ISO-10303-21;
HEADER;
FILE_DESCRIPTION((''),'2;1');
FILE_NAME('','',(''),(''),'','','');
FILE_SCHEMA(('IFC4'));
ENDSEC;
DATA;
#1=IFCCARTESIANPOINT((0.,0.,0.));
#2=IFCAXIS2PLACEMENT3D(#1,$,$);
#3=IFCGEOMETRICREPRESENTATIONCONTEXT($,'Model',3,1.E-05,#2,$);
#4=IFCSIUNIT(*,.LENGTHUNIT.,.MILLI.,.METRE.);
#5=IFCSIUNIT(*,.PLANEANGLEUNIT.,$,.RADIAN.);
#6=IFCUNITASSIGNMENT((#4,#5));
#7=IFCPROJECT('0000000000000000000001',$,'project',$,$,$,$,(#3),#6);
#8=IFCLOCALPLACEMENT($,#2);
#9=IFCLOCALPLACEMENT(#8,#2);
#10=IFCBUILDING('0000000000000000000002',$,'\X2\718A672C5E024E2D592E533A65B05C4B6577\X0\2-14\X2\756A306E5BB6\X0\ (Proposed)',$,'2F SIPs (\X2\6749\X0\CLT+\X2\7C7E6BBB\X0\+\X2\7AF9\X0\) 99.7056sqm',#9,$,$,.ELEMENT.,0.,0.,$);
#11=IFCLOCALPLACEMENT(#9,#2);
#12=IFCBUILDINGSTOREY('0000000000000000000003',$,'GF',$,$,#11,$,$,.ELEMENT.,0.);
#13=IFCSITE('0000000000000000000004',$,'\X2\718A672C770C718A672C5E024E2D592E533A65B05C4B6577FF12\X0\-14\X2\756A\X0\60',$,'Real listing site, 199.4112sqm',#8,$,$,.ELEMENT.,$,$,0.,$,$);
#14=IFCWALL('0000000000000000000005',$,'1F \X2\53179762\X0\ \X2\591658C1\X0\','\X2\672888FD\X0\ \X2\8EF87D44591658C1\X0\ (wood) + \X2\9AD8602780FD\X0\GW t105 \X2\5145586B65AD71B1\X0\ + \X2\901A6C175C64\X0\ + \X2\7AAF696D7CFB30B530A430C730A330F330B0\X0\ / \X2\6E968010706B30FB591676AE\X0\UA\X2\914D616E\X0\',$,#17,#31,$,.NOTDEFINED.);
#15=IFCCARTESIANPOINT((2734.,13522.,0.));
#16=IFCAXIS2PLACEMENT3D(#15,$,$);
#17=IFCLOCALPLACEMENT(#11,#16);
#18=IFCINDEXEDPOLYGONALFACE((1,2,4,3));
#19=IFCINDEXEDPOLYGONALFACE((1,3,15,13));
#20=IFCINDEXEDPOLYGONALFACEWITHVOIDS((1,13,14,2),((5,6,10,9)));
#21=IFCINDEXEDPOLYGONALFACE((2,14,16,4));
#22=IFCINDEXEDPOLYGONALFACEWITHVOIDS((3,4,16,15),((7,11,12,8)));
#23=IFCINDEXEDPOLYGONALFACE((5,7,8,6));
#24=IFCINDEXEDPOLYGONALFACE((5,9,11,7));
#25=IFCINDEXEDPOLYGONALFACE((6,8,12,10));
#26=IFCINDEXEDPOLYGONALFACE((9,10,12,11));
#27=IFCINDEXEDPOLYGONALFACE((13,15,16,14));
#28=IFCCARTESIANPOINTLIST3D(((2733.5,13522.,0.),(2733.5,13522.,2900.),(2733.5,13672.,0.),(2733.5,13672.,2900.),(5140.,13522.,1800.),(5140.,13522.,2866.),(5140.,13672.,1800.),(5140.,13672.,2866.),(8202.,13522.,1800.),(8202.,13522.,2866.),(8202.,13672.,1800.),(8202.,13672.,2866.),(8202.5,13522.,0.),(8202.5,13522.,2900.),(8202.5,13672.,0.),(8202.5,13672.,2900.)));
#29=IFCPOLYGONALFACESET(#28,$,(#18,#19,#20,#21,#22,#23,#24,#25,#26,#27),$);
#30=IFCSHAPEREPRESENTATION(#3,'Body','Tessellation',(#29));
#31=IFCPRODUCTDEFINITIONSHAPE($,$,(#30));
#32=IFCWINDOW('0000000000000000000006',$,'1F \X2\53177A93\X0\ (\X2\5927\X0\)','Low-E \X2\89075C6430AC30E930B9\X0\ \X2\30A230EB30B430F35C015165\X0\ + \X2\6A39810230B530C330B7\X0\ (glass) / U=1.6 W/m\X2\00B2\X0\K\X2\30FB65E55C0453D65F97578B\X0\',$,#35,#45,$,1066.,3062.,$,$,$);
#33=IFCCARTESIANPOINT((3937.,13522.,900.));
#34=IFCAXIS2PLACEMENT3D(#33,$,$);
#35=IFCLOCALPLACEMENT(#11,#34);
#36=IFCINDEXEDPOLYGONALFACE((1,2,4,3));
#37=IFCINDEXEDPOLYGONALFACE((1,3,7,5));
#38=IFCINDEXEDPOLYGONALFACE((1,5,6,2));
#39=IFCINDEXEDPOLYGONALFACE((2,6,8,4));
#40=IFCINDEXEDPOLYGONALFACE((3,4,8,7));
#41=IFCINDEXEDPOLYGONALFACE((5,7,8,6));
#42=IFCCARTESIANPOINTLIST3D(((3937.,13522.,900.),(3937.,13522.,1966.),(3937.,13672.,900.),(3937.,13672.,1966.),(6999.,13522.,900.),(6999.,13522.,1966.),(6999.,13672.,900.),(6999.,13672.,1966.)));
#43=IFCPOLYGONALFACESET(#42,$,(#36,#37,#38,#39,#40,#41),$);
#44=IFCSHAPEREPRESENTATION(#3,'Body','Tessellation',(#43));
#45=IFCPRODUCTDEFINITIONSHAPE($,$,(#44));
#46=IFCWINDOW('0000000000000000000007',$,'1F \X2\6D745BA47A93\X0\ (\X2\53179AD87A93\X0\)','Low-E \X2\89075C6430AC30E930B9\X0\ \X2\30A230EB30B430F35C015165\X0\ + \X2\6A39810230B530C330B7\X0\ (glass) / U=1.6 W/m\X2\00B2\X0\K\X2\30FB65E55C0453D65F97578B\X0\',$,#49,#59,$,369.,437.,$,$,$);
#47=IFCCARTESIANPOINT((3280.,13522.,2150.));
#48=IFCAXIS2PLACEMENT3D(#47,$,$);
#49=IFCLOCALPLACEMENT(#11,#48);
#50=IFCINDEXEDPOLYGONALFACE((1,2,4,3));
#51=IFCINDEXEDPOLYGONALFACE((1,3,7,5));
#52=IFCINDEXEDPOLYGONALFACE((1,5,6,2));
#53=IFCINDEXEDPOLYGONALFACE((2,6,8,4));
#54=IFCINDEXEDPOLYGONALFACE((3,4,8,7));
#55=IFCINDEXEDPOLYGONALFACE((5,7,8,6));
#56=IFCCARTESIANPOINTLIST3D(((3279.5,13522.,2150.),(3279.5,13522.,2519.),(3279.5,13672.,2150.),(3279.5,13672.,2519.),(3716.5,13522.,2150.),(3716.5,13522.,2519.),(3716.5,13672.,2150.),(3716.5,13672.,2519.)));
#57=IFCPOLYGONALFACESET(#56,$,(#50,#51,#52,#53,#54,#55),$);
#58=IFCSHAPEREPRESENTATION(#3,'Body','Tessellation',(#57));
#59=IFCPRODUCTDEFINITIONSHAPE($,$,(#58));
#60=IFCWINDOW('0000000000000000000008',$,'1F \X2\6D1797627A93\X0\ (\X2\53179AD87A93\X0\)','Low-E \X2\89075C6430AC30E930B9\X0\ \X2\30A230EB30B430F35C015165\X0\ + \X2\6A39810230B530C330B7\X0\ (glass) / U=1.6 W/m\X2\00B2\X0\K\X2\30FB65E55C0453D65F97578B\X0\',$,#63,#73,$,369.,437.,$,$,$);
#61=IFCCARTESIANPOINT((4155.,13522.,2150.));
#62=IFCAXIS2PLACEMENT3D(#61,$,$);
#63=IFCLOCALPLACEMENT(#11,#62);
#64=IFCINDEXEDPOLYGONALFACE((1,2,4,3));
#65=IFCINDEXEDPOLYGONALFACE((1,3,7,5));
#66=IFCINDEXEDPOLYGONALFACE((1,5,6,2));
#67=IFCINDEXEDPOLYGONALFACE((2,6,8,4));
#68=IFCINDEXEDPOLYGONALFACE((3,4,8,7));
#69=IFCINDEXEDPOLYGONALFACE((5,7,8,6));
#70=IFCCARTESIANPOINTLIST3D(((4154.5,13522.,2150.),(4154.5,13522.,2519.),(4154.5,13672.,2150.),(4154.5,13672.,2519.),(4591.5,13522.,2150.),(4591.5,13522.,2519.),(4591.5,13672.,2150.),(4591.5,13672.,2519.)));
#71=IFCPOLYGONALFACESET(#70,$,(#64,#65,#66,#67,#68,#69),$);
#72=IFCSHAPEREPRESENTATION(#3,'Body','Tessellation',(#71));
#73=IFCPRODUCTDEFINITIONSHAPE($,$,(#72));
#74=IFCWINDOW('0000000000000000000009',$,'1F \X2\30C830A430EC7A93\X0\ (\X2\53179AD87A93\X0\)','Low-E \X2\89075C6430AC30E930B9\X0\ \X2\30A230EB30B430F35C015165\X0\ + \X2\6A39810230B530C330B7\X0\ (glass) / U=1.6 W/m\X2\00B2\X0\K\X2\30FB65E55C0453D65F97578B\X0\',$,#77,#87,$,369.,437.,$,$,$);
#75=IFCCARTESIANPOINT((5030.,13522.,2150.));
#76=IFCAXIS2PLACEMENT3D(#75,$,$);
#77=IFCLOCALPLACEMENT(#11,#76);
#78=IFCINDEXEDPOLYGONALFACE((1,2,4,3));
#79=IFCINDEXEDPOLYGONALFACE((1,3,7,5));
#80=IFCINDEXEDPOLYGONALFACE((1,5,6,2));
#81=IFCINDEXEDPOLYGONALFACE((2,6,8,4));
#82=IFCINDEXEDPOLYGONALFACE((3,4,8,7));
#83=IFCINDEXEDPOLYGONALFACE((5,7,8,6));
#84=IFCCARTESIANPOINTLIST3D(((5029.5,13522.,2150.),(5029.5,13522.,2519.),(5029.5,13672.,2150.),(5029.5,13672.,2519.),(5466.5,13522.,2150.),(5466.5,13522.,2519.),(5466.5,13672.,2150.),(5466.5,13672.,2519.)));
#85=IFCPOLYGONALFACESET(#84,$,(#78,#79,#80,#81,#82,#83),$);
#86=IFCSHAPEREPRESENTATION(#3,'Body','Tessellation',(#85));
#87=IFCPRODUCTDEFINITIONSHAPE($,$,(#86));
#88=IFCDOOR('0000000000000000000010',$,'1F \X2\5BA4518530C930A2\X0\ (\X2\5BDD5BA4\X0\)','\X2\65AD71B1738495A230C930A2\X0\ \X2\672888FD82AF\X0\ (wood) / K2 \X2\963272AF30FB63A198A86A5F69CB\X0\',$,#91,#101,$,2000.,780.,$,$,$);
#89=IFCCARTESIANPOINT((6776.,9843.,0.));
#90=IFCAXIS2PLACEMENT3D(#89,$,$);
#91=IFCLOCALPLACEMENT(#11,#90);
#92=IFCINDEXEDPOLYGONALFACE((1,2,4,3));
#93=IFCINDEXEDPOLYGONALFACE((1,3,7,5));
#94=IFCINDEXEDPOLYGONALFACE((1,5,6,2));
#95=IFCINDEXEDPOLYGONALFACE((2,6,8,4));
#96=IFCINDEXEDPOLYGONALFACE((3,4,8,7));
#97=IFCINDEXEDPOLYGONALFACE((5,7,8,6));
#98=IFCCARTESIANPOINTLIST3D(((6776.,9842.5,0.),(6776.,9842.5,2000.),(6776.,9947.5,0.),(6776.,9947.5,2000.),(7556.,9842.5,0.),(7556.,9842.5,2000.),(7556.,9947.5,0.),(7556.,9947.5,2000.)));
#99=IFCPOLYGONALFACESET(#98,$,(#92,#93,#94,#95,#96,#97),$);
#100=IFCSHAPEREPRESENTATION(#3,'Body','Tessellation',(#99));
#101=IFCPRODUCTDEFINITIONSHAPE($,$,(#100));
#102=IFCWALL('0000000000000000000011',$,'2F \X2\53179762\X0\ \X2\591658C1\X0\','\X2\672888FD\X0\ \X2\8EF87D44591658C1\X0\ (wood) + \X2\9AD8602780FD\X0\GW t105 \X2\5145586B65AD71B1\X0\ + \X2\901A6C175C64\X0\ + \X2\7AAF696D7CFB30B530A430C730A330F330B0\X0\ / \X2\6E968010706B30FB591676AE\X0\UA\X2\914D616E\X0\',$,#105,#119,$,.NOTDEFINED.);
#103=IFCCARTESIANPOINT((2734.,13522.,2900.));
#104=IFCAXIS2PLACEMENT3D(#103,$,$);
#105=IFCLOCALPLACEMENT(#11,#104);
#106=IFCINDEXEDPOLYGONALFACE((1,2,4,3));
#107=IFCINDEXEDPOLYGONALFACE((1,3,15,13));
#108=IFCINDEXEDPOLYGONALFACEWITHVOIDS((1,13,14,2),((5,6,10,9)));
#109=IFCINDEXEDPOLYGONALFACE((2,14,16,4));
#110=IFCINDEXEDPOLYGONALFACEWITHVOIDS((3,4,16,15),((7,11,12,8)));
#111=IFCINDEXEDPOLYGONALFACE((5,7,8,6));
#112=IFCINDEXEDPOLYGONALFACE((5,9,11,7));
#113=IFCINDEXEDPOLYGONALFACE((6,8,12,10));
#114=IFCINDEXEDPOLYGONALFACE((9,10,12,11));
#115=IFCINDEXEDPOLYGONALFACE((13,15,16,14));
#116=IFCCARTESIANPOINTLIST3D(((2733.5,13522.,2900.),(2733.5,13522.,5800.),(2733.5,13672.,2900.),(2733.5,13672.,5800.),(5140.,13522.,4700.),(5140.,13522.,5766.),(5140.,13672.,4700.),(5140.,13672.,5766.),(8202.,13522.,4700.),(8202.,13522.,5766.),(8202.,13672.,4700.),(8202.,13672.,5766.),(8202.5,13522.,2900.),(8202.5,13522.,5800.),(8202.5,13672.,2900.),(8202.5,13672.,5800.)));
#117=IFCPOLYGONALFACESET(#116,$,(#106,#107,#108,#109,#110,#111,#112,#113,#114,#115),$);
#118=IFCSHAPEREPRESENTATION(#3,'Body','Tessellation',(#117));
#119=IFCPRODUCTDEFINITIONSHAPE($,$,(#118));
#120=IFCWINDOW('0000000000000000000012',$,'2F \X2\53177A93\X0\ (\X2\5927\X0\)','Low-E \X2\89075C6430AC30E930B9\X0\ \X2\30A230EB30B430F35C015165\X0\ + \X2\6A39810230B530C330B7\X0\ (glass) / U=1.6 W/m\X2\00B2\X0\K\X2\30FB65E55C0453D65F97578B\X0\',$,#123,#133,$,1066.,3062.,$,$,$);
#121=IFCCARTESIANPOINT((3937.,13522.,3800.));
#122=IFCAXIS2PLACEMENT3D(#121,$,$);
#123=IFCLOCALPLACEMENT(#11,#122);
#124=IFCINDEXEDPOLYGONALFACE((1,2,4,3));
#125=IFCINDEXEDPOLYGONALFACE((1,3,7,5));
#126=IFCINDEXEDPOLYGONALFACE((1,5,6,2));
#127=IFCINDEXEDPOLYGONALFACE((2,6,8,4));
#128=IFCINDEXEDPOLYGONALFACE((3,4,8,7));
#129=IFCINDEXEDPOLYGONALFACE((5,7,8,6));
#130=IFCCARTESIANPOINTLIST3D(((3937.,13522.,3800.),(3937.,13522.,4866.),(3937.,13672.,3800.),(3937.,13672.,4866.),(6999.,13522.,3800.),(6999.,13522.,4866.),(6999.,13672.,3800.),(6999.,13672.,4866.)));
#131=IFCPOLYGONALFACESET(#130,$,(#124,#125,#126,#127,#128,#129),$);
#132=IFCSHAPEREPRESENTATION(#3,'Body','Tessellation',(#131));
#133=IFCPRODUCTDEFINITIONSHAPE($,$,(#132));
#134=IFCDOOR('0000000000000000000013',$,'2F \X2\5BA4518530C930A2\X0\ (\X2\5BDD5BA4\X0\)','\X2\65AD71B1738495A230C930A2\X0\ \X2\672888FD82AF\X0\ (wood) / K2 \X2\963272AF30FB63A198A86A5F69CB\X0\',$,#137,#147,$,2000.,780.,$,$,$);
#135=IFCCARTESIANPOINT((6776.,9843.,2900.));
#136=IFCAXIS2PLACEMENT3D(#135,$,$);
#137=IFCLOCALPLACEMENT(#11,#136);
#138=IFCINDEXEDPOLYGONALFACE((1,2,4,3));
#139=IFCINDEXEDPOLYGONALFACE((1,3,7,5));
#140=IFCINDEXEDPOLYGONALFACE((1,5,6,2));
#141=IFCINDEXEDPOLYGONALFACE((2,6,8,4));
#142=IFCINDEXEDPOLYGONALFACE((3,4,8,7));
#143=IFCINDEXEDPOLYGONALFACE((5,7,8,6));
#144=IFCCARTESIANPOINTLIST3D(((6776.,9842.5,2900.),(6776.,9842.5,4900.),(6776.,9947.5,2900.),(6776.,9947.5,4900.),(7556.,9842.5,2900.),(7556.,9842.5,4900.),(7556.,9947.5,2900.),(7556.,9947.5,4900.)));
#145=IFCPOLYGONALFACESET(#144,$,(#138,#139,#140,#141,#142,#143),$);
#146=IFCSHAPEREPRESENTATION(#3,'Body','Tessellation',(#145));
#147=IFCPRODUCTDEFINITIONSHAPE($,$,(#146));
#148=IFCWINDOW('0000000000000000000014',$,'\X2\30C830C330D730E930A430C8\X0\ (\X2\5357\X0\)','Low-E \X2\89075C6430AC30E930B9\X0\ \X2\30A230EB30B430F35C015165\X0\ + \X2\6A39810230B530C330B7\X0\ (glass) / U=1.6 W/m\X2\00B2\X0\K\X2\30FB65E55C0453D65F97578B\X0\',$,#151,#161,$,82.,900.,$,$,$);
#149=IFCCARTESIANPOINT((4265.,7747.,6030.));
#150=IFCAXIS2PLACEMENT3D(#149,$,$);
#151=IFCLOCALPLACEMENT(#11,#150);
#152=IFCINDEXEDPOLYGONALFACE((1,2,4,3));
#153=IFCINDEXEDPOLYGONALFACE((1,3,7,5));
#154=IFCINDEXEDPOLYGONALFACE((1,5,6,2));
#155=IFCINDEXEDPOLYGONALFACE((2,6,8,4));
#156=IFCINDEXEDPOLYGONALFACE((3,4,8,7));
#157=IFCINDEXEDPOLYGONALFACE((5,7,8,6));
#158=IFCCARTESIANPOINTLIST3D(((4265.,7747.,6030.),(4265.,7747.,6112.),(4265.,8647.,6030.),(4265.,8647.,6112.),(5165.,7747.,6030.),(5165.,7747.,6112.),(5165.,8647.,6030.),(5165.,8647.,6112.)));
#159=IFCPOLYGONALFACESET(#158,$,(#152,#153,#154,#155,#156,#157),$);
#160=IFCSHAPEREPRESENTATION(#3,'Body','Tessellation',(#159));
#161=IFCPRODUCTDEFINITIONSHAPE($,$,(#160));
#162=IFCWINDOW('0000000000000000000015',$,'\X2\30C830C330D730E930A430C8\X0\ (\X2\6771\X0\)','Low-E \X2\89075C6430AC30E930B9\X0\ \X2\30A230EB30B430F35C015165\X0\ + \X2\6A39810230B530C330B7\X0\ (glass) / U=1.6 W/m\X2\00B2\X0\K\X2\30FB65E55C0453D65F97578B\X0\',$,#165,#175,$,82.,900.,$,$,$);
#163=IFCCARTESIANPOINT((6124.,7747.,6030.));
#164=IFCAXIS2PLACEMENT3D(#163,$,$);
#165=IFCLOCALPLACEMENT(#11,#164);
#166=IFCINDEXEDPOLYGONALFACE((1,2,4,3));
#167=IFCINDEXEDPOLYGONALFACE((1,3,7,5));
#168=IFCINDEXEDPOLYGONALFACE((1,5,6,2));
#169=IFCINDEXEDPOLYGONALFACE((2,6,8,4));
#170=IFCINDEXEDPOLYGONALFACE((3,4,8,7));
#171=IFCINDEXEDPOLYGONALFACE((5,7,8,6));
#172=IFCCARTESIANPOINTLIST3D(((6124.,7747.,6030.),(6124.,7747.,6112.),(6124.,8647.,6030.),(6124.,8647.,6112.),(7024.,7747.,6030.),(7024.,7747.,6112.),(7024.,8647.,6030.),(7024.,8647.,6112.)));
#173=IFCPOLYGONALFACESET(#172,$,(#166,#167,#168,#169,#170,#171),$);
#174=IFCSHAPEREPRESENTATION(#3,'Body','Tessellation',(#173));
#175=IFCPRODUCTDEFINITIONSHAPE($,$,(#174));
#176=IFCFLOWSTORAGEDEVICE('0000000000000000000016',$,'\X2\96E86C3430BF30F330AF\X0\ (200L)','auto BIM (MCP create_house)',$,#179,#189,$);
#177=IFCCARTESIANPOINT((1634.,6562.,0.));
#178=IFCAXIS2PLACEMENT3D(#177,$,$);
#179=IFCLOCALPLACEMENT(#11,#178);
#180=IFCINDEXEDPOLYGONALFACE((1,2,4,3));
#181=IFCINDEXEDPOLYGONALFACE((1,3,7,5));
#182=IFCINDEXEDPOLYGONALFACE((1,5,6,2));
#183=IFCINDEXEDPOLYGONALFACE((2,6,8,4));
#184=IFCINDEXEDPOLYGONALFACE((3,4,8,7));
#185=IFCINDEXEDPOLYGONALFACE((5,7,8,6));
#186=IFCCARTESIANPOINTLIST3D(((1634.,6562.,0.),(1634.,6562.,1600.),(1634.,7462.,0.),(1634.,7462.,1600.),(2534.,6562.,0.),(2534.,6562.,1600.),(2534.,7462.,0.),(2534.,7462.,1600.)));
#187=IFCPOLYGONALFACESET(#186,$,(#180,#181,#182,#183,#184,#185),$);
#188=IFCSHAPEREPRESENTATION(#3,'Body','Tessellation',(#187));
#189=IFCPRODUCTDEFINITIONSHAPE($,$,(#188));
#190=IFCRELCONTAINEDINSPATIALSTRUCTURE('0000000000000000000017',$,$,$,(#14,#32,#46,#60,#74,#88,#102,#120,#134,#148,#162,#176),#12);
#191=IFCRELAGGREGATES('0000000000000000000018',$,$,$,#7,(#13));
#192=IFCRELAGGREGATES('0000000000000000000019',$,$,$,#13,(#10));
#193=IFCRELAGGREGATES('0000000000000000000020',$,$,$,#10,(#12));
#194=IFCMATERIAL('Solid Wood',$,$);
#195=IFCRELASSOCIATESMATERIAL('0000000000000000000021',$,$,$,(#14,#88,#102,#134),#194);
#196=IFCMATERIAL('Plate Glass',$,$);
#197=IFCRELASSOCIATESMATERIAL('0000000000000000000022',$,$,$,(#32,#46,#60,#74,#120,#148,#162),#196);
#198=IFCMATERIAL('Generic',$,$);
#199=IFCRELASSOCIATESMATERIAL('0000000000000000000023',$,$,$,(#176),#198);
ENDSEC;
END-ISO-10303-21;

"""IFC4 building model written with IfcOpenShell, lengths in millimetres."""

from ifc_helpers import new_model, si_unit, frame, frame_2d, origin, place, context, project, spatial, rectangle, extrude, material, element, fill, save


model = new_model("IFC4")

# Units and contexts
model_context = context("Model", 3, precision=1e-05, world=origin())
ifc_project = project(units=[si_unit("LENGTHUNIT", "METRE", prefix="MILLI"), si_unit("PLANEANGLEUNIT", "RADIAN")], contexts=[model_context])

# Site, building, storey
site_placement = place(None, origin())
site = spatial("IfcSite", under=ifc_project, at=site_placement, Name="熊本県熊本市中央区新屋敷２-14番60", ObjectType="Real listing site, 199.4112sqm", CompositionType="ELEMENT", RefElevation=0.0)
building_placement = place(site_placement, origin())
building = spatial("IfcBuilding", under=site, at=building_placement, Name="熊本市中央区新屋敷2-14番の家 (Proposed)", ObjectType="2F SIPs (杉CLT+籾殻+竹) 99.7056sqm", CompositionType="ELEMENT", ElevationOfRefHeight=0.0, ElevationOfTerrain=0.0)
storey_placement = place(building_placement, origin())
storey = spatial("IfcBuildingStorey", under=building, at=storey_placement, Name="GF", CompositionType="ELEMENT", Elevation=0.0)

# Wall, openings, windows
ifc_material_1 = material(Name="Solid Wood")
wall_1_placement = place(storey_placement, frame((2734.0, 13522.0, 0.0)))
wall_1 = element("IfcWall", 1, at=wall_1_placement, inside=storey, material=ifc_material_1, Name="1F 北面 外壁", Description="木製 軸組外壁 (wood) + 高性能GW t105 充填断熱 + 通気層 + 窯業系サイディング / 準耐火・外皮UA配慮", PredefinedType="NOTDEFINED", context=model_context, shape_type="SweptSolid", body=[
    extrude(rectangle(XDim=5469.0, YDim=150.0, at=frame_2d((2734.0, 75.0))), frame((2734.0, 13522.0, 0.0)), (0.0, 0.0, 1.0), 2900.0),
])
opening_1_placement = place(storey_placement, frame((3937.0, 13522.0, 900.0)))
opening_1 = element("IfcOpeningElement", 2, at=opening_1_placement, cuts=wall_1, PredefinedType="NOTDEFINED", context=model_context, shape_type="SweptSolid", body=[
    extrude(rectangle(XDim=3062.0, YDim=150.0, at=frame_2d((1531.0, 75.0))), frame((3937.0, 13522.0, 900.0)), (0.0, 0.0, 1.0), 1066.0),
])
opening_2_placement = place(storey_placement, frame((3280.0, 13522.0, 2150.0)))
opening_2 = element("IfcOpeningElement", 3, at=opening_2_placement, cuts=wall_1, PredefinedType="NOTDEFINED", context=model_context, shape_type="SweptSolid", body=[
    extrude(rectangle(XDim=437.0, YDim=150.0, at=frame_2d((218.0, 75.0))), frame((3280.0, 13522.0, 2150.0)), (0.0, 0.0, 1.0), 369.0),
])
opening_3_placement = place(storey_placement, frame((4155.0, 13522.0, 2150.0)))
opening_3 = element("IfcOpeningElement", 4, at=opening_3_placement, cuts=wall_1, PredefinedType="NOTDEFINED", context=model_context, shape_type="SweptSolid", body=[
    extrude(rectangle(XDim=437.0, YDim=150.0, at=frame_2d((218.0, 75.0))), frame((4155.0, 13522.0, 2150.0)), (0.0, 0.0, 1.0), 369.0),
])
opening_4_placement = place(storey_placement, frame((5030.0, 13522.0, 2150.0)))
opening_4 = element("IfcOpeningElement", 5, at=opening_4_placement, cuts=wall_1, PredefinedType="NOTDEFINED", context=model_context, shape_type="SweptSolid", body=[
    extrude(rectangle(XDim=437.0, YDim=150.0, at=frame_2d((218.0, 75.0))), frame((5030.0, 13522.0, 2150.0)), (0.0, 0.0, 1.0), 369.0),
])
ifc_material_2 = material(Name="Plate Glass")
window_1_placement = place(storey_placement, frame((3937.0, 13522.0, 900.0)))
window_1 = element("IfcWindow", 6, at=window_1_placement, inside=storey, material=ifc_material_2, Name="1F 北窓 (大)", Description="Low-E 複層ガラス アルゴン封入 + 樹脂サッシ (glass) / U=1.6 W/m²K・日射取得型", OverallHeight=1066.0, OverallWidth=3062.0, context=model_context, shape_type="SweptSolid", body=[
    extrude(rectangle(XDim=3062.0, YDim=150.0, at=frame_2d((1531.0, 75.0))), frame((3937.0, 13522.0, 900.0)), (0.0, 0.0, 1.0), 1066.0),
])
fill(opening_1, window_1)
window_2_placement = place(storey_placement, frame((3280.0, 13522.0, 2150.0)))
window_2 = element("IfcWindow", 7, at=window_2_placement, inside=storey, material=ifc_material_2, Name="1F 浴室窓 (北高窓)", Description="Low-E 複層ガラス アルゴン封入 + 樹脂サッシ (glass) / U=1.6 W/m²K・日射取得型", OverallHeight=369.0, OverallWidth=437.0, context=model_context, shape_type="SweptSolid", body=[
    extrude(rectangle(XDim=437.0, YDim=150.0, at=frame_2d((218.0, 75.0))), frame((3280.0, 13522.0, 2150.0)), (0.0, 0.0, 1.0), 369.0),
])
fill(opening_2, window_2)
window_3_placement = place(storey_placement, frame((4155.0, 13522.0, 2150.0)))
window_3 = element("IfcWindow", 8, at=window_3_placement, inside=storey, material=ifc_material_2, Name="1F 洗面窓 (北高窓)", Description="Low-E 複層ガラス アルゴン封入 + 樹脂サッシ (glass) / U=1.6 W/m²K・日射取得型", OverallHeight=369.0, OverallWidth=437.0, context=model_context, shape_type="SweptSolid", body=[
    extrude(rectangle(XDim=437.0, YDim=150.0, at=frame_2d((218.0, 75.0))), frame((4155.0, 13522.0, 2150.0)), (0.0, 0.0, 1.0), 369.0),
])
fill(opening_3, window_3)
window_4_placement = place(storey_placement, frame((5030.0, 13522.0, 2150.0)))
window_4 = element("IfcWindow", 9, at=window_4_placement, inside=storey, material=ifc_material_2, Name="1F トイレ窓 (北高窓)", Description="Low-E 複層ガラス アルゴン封入 + 樹脂サッシ (glass) / U=1.6 W/m²K・日射取得型", OverallHeight=369.0, OverallWidth=437.0, context=model_context, shape_type="SweptSolid", body=[
    extrude(rectangle(XDim=437.0, YDim=150.0, at=frame_2d((218.0, 75.0))), frame((5030.0, 13522.0, 2150.0)), (0.0, 0.0, 1.0), 369.0),
])
fill(opening_4, window_4)

# Door
door_1_placement = place(storey_placement, frame((6776.0, 9843.0, 0.0)))
element("IfcDoor", 10, at=door_1_placement, inside=storey, material=ifc_material_1, Name="1F 室内ドア (寝室)", Description="断熱玄関ドア 木製芯 (wood) / K2 防犯・採風機構", OverallHeight=2000.0, OverallWidth=780.0, context=model_context, shape_type="SweptSolid", body=[
    extrude(rectangle(XDim=780.0, YDim=105.0, at=frame_2d((390.0, 52.0))), frame((6776.0, 9843.0, 0.0)), (0.0, 0.0, 1.0), 2000.0),
])

# Wall, opening, window
wall_2_placement = place(storey_placement, frame((2734.0, 13522.0, 2900.0)))
wall_2 = element("IfcWall", 11, at=wall_2_placement, inside=storey, material=ifc_material_1, Name="2F 北面 外壁", Description="木製 軸組外壁 (wood) + 高性能GW t105 充填断熱 + 通気層 + 窯業系サイディング / 準耐火・外皮UA配慮", PredefinedType="NOTDEFINED", context=model_context, shape_type="SweptSolid", body=[
    extrude(rectangle(XDim=5469.0, YDim=150.0, at=frame_2d((2734.0, 75.0))), frame((2734.0, 13522.0, 2900.0)), (0.0, 0.0, 1.0), 2900.0),
])
opening_5_placement = place(storey_placement, frame((3937.0, 13522.0, 3800.0)))
opening_5 = element("IfcOpeningElement", 12, at=opening_5_placement, cuts=wall_2, PredefinedType="NOTDEFINED", context=model_context, shape_type="SweptSolid", body=[
    extrude(rectangle(XDim=3062.0, YDim=150.0, at=frame_2d((1531.0, 75.0))), frame((3937.0, 13522.0, 3800.0)), (0.0, 0.0, 1.0), 1066.0),
])
window_5_placement = place(storey_placement, frame((3937.0, 13522.0, 3800.0)))
window_5 = element("IfcWindow", 13, at=window_5_placement, inside=storey, material=ifc_material_2, Name="2F 北窓 (大)", Description="Low-E 複層ガラス アルゴン封入 + 樹脂サッシ (glass) / U=1.6 W/m²K・日射取得型", OverallHeight=1066.0, OverallWidth=3062.0, context=model_context, shape_type="SweptSolid", body=[
    extrude(rectangle(XDim=3062.0, YDim=150.0, at=frame_2d((1531.0, 75.0))), frame((3937.0, 13522.0, 3800.0)), (0.0, 0.0, 1.0), 1066.0),
])
fill(opening_5, window_5)

# Door
door_2_placement = place(storey_placement, frame((6776.0, 9843.0, 2900.0)))
element("IfcDoor", 14, at=door_2_placement, inside=storey, material=ifc_material_1, Name="2F 室内ドア (寝室)", Description="断熱玄関ドア 木製芯 (wood) / K2 防犯・採風機構", OverallHeight=2000.0, OverallWidth=780.0, context=model_context, shape_type="SweptSolid", body=[
    extrude(rectangle(XDim=780.0, YDim=105.0, at=frame_2d((390.0, 52.0))), frame((6776.0, 9843.0, 2900.0)), (0.0, 0.0, 1.0), 2000.0),
])

# Windows
window_6_placement = place(storey_placement, frame((4265.0, 7747.0, 6030.0)))
element("IfcWindow", 15, at=window_6_placement, inside=storey, material=ifc_material_2, Name="トップライト (南)", Description="Low-E 複層ガラス アルゴン封入 + 樹脂サッシ (glass) / U=1.6 W/m²K・日射取得型", OverallHeight=82.0, OverallWidth=900.0, context=model_context, shape_type="SweptSolid", body=[
    extrude(rectangle(XDim=900.0, YDim=900.0, at=frame_2d((450.0, 450.0))), frame((4265.0, 7747.0, 6030.0)), (0.0, 0.0, 1.0), 82.0),
])
window_7_placement = place(storey_placement, frame((6124.0, 7747.0, 6030.0)))
element("IfcWindow", 16, at=window_7_placement, inside=storey, material=ifc_material_2, Name="トップライト (東)", Description="Low-E 複層ガラス アルゴン封入 + 樹脂サッシ (glass) / U=1.6 W/m²K・日射取得型", OverallHeight=82.0, OverallWidth=900.0, context=model_context, shape_type="SweptSolid", body=[
    extrude(rectangle(XDim=900.0, YDim=900.0, at=frame_2d((450.0, 450.0))), frame((6124.0, 7747.0, 6030.0)), (0.0, 0.0, 1.0), 82.0),
])

# Flow storage device
ifc_material_3 = material(Name="Generic")
flow_storage_device_placement = place(storey_placement, frame((1634.0, 6562.0, 0.0)))
element("IfcFlowStorageDevice", 17, at=flow_storage_device_placement, inside=storey, material=ifc_material_3, Name="雨水タンク (200L)", Description="auto BIM (MCP create_house)", context=model_context, shape_type="SweptSolid", body=[
    extrude(rectangle(XDim=900.0, YDim=900.0, at=frame_2d((450.0, 450.0))), frame((1634.0, 6562.0, 0.0)), (0.0, 0.0, 1.0), 1600.0),
])

save(model, "model.ifc")
